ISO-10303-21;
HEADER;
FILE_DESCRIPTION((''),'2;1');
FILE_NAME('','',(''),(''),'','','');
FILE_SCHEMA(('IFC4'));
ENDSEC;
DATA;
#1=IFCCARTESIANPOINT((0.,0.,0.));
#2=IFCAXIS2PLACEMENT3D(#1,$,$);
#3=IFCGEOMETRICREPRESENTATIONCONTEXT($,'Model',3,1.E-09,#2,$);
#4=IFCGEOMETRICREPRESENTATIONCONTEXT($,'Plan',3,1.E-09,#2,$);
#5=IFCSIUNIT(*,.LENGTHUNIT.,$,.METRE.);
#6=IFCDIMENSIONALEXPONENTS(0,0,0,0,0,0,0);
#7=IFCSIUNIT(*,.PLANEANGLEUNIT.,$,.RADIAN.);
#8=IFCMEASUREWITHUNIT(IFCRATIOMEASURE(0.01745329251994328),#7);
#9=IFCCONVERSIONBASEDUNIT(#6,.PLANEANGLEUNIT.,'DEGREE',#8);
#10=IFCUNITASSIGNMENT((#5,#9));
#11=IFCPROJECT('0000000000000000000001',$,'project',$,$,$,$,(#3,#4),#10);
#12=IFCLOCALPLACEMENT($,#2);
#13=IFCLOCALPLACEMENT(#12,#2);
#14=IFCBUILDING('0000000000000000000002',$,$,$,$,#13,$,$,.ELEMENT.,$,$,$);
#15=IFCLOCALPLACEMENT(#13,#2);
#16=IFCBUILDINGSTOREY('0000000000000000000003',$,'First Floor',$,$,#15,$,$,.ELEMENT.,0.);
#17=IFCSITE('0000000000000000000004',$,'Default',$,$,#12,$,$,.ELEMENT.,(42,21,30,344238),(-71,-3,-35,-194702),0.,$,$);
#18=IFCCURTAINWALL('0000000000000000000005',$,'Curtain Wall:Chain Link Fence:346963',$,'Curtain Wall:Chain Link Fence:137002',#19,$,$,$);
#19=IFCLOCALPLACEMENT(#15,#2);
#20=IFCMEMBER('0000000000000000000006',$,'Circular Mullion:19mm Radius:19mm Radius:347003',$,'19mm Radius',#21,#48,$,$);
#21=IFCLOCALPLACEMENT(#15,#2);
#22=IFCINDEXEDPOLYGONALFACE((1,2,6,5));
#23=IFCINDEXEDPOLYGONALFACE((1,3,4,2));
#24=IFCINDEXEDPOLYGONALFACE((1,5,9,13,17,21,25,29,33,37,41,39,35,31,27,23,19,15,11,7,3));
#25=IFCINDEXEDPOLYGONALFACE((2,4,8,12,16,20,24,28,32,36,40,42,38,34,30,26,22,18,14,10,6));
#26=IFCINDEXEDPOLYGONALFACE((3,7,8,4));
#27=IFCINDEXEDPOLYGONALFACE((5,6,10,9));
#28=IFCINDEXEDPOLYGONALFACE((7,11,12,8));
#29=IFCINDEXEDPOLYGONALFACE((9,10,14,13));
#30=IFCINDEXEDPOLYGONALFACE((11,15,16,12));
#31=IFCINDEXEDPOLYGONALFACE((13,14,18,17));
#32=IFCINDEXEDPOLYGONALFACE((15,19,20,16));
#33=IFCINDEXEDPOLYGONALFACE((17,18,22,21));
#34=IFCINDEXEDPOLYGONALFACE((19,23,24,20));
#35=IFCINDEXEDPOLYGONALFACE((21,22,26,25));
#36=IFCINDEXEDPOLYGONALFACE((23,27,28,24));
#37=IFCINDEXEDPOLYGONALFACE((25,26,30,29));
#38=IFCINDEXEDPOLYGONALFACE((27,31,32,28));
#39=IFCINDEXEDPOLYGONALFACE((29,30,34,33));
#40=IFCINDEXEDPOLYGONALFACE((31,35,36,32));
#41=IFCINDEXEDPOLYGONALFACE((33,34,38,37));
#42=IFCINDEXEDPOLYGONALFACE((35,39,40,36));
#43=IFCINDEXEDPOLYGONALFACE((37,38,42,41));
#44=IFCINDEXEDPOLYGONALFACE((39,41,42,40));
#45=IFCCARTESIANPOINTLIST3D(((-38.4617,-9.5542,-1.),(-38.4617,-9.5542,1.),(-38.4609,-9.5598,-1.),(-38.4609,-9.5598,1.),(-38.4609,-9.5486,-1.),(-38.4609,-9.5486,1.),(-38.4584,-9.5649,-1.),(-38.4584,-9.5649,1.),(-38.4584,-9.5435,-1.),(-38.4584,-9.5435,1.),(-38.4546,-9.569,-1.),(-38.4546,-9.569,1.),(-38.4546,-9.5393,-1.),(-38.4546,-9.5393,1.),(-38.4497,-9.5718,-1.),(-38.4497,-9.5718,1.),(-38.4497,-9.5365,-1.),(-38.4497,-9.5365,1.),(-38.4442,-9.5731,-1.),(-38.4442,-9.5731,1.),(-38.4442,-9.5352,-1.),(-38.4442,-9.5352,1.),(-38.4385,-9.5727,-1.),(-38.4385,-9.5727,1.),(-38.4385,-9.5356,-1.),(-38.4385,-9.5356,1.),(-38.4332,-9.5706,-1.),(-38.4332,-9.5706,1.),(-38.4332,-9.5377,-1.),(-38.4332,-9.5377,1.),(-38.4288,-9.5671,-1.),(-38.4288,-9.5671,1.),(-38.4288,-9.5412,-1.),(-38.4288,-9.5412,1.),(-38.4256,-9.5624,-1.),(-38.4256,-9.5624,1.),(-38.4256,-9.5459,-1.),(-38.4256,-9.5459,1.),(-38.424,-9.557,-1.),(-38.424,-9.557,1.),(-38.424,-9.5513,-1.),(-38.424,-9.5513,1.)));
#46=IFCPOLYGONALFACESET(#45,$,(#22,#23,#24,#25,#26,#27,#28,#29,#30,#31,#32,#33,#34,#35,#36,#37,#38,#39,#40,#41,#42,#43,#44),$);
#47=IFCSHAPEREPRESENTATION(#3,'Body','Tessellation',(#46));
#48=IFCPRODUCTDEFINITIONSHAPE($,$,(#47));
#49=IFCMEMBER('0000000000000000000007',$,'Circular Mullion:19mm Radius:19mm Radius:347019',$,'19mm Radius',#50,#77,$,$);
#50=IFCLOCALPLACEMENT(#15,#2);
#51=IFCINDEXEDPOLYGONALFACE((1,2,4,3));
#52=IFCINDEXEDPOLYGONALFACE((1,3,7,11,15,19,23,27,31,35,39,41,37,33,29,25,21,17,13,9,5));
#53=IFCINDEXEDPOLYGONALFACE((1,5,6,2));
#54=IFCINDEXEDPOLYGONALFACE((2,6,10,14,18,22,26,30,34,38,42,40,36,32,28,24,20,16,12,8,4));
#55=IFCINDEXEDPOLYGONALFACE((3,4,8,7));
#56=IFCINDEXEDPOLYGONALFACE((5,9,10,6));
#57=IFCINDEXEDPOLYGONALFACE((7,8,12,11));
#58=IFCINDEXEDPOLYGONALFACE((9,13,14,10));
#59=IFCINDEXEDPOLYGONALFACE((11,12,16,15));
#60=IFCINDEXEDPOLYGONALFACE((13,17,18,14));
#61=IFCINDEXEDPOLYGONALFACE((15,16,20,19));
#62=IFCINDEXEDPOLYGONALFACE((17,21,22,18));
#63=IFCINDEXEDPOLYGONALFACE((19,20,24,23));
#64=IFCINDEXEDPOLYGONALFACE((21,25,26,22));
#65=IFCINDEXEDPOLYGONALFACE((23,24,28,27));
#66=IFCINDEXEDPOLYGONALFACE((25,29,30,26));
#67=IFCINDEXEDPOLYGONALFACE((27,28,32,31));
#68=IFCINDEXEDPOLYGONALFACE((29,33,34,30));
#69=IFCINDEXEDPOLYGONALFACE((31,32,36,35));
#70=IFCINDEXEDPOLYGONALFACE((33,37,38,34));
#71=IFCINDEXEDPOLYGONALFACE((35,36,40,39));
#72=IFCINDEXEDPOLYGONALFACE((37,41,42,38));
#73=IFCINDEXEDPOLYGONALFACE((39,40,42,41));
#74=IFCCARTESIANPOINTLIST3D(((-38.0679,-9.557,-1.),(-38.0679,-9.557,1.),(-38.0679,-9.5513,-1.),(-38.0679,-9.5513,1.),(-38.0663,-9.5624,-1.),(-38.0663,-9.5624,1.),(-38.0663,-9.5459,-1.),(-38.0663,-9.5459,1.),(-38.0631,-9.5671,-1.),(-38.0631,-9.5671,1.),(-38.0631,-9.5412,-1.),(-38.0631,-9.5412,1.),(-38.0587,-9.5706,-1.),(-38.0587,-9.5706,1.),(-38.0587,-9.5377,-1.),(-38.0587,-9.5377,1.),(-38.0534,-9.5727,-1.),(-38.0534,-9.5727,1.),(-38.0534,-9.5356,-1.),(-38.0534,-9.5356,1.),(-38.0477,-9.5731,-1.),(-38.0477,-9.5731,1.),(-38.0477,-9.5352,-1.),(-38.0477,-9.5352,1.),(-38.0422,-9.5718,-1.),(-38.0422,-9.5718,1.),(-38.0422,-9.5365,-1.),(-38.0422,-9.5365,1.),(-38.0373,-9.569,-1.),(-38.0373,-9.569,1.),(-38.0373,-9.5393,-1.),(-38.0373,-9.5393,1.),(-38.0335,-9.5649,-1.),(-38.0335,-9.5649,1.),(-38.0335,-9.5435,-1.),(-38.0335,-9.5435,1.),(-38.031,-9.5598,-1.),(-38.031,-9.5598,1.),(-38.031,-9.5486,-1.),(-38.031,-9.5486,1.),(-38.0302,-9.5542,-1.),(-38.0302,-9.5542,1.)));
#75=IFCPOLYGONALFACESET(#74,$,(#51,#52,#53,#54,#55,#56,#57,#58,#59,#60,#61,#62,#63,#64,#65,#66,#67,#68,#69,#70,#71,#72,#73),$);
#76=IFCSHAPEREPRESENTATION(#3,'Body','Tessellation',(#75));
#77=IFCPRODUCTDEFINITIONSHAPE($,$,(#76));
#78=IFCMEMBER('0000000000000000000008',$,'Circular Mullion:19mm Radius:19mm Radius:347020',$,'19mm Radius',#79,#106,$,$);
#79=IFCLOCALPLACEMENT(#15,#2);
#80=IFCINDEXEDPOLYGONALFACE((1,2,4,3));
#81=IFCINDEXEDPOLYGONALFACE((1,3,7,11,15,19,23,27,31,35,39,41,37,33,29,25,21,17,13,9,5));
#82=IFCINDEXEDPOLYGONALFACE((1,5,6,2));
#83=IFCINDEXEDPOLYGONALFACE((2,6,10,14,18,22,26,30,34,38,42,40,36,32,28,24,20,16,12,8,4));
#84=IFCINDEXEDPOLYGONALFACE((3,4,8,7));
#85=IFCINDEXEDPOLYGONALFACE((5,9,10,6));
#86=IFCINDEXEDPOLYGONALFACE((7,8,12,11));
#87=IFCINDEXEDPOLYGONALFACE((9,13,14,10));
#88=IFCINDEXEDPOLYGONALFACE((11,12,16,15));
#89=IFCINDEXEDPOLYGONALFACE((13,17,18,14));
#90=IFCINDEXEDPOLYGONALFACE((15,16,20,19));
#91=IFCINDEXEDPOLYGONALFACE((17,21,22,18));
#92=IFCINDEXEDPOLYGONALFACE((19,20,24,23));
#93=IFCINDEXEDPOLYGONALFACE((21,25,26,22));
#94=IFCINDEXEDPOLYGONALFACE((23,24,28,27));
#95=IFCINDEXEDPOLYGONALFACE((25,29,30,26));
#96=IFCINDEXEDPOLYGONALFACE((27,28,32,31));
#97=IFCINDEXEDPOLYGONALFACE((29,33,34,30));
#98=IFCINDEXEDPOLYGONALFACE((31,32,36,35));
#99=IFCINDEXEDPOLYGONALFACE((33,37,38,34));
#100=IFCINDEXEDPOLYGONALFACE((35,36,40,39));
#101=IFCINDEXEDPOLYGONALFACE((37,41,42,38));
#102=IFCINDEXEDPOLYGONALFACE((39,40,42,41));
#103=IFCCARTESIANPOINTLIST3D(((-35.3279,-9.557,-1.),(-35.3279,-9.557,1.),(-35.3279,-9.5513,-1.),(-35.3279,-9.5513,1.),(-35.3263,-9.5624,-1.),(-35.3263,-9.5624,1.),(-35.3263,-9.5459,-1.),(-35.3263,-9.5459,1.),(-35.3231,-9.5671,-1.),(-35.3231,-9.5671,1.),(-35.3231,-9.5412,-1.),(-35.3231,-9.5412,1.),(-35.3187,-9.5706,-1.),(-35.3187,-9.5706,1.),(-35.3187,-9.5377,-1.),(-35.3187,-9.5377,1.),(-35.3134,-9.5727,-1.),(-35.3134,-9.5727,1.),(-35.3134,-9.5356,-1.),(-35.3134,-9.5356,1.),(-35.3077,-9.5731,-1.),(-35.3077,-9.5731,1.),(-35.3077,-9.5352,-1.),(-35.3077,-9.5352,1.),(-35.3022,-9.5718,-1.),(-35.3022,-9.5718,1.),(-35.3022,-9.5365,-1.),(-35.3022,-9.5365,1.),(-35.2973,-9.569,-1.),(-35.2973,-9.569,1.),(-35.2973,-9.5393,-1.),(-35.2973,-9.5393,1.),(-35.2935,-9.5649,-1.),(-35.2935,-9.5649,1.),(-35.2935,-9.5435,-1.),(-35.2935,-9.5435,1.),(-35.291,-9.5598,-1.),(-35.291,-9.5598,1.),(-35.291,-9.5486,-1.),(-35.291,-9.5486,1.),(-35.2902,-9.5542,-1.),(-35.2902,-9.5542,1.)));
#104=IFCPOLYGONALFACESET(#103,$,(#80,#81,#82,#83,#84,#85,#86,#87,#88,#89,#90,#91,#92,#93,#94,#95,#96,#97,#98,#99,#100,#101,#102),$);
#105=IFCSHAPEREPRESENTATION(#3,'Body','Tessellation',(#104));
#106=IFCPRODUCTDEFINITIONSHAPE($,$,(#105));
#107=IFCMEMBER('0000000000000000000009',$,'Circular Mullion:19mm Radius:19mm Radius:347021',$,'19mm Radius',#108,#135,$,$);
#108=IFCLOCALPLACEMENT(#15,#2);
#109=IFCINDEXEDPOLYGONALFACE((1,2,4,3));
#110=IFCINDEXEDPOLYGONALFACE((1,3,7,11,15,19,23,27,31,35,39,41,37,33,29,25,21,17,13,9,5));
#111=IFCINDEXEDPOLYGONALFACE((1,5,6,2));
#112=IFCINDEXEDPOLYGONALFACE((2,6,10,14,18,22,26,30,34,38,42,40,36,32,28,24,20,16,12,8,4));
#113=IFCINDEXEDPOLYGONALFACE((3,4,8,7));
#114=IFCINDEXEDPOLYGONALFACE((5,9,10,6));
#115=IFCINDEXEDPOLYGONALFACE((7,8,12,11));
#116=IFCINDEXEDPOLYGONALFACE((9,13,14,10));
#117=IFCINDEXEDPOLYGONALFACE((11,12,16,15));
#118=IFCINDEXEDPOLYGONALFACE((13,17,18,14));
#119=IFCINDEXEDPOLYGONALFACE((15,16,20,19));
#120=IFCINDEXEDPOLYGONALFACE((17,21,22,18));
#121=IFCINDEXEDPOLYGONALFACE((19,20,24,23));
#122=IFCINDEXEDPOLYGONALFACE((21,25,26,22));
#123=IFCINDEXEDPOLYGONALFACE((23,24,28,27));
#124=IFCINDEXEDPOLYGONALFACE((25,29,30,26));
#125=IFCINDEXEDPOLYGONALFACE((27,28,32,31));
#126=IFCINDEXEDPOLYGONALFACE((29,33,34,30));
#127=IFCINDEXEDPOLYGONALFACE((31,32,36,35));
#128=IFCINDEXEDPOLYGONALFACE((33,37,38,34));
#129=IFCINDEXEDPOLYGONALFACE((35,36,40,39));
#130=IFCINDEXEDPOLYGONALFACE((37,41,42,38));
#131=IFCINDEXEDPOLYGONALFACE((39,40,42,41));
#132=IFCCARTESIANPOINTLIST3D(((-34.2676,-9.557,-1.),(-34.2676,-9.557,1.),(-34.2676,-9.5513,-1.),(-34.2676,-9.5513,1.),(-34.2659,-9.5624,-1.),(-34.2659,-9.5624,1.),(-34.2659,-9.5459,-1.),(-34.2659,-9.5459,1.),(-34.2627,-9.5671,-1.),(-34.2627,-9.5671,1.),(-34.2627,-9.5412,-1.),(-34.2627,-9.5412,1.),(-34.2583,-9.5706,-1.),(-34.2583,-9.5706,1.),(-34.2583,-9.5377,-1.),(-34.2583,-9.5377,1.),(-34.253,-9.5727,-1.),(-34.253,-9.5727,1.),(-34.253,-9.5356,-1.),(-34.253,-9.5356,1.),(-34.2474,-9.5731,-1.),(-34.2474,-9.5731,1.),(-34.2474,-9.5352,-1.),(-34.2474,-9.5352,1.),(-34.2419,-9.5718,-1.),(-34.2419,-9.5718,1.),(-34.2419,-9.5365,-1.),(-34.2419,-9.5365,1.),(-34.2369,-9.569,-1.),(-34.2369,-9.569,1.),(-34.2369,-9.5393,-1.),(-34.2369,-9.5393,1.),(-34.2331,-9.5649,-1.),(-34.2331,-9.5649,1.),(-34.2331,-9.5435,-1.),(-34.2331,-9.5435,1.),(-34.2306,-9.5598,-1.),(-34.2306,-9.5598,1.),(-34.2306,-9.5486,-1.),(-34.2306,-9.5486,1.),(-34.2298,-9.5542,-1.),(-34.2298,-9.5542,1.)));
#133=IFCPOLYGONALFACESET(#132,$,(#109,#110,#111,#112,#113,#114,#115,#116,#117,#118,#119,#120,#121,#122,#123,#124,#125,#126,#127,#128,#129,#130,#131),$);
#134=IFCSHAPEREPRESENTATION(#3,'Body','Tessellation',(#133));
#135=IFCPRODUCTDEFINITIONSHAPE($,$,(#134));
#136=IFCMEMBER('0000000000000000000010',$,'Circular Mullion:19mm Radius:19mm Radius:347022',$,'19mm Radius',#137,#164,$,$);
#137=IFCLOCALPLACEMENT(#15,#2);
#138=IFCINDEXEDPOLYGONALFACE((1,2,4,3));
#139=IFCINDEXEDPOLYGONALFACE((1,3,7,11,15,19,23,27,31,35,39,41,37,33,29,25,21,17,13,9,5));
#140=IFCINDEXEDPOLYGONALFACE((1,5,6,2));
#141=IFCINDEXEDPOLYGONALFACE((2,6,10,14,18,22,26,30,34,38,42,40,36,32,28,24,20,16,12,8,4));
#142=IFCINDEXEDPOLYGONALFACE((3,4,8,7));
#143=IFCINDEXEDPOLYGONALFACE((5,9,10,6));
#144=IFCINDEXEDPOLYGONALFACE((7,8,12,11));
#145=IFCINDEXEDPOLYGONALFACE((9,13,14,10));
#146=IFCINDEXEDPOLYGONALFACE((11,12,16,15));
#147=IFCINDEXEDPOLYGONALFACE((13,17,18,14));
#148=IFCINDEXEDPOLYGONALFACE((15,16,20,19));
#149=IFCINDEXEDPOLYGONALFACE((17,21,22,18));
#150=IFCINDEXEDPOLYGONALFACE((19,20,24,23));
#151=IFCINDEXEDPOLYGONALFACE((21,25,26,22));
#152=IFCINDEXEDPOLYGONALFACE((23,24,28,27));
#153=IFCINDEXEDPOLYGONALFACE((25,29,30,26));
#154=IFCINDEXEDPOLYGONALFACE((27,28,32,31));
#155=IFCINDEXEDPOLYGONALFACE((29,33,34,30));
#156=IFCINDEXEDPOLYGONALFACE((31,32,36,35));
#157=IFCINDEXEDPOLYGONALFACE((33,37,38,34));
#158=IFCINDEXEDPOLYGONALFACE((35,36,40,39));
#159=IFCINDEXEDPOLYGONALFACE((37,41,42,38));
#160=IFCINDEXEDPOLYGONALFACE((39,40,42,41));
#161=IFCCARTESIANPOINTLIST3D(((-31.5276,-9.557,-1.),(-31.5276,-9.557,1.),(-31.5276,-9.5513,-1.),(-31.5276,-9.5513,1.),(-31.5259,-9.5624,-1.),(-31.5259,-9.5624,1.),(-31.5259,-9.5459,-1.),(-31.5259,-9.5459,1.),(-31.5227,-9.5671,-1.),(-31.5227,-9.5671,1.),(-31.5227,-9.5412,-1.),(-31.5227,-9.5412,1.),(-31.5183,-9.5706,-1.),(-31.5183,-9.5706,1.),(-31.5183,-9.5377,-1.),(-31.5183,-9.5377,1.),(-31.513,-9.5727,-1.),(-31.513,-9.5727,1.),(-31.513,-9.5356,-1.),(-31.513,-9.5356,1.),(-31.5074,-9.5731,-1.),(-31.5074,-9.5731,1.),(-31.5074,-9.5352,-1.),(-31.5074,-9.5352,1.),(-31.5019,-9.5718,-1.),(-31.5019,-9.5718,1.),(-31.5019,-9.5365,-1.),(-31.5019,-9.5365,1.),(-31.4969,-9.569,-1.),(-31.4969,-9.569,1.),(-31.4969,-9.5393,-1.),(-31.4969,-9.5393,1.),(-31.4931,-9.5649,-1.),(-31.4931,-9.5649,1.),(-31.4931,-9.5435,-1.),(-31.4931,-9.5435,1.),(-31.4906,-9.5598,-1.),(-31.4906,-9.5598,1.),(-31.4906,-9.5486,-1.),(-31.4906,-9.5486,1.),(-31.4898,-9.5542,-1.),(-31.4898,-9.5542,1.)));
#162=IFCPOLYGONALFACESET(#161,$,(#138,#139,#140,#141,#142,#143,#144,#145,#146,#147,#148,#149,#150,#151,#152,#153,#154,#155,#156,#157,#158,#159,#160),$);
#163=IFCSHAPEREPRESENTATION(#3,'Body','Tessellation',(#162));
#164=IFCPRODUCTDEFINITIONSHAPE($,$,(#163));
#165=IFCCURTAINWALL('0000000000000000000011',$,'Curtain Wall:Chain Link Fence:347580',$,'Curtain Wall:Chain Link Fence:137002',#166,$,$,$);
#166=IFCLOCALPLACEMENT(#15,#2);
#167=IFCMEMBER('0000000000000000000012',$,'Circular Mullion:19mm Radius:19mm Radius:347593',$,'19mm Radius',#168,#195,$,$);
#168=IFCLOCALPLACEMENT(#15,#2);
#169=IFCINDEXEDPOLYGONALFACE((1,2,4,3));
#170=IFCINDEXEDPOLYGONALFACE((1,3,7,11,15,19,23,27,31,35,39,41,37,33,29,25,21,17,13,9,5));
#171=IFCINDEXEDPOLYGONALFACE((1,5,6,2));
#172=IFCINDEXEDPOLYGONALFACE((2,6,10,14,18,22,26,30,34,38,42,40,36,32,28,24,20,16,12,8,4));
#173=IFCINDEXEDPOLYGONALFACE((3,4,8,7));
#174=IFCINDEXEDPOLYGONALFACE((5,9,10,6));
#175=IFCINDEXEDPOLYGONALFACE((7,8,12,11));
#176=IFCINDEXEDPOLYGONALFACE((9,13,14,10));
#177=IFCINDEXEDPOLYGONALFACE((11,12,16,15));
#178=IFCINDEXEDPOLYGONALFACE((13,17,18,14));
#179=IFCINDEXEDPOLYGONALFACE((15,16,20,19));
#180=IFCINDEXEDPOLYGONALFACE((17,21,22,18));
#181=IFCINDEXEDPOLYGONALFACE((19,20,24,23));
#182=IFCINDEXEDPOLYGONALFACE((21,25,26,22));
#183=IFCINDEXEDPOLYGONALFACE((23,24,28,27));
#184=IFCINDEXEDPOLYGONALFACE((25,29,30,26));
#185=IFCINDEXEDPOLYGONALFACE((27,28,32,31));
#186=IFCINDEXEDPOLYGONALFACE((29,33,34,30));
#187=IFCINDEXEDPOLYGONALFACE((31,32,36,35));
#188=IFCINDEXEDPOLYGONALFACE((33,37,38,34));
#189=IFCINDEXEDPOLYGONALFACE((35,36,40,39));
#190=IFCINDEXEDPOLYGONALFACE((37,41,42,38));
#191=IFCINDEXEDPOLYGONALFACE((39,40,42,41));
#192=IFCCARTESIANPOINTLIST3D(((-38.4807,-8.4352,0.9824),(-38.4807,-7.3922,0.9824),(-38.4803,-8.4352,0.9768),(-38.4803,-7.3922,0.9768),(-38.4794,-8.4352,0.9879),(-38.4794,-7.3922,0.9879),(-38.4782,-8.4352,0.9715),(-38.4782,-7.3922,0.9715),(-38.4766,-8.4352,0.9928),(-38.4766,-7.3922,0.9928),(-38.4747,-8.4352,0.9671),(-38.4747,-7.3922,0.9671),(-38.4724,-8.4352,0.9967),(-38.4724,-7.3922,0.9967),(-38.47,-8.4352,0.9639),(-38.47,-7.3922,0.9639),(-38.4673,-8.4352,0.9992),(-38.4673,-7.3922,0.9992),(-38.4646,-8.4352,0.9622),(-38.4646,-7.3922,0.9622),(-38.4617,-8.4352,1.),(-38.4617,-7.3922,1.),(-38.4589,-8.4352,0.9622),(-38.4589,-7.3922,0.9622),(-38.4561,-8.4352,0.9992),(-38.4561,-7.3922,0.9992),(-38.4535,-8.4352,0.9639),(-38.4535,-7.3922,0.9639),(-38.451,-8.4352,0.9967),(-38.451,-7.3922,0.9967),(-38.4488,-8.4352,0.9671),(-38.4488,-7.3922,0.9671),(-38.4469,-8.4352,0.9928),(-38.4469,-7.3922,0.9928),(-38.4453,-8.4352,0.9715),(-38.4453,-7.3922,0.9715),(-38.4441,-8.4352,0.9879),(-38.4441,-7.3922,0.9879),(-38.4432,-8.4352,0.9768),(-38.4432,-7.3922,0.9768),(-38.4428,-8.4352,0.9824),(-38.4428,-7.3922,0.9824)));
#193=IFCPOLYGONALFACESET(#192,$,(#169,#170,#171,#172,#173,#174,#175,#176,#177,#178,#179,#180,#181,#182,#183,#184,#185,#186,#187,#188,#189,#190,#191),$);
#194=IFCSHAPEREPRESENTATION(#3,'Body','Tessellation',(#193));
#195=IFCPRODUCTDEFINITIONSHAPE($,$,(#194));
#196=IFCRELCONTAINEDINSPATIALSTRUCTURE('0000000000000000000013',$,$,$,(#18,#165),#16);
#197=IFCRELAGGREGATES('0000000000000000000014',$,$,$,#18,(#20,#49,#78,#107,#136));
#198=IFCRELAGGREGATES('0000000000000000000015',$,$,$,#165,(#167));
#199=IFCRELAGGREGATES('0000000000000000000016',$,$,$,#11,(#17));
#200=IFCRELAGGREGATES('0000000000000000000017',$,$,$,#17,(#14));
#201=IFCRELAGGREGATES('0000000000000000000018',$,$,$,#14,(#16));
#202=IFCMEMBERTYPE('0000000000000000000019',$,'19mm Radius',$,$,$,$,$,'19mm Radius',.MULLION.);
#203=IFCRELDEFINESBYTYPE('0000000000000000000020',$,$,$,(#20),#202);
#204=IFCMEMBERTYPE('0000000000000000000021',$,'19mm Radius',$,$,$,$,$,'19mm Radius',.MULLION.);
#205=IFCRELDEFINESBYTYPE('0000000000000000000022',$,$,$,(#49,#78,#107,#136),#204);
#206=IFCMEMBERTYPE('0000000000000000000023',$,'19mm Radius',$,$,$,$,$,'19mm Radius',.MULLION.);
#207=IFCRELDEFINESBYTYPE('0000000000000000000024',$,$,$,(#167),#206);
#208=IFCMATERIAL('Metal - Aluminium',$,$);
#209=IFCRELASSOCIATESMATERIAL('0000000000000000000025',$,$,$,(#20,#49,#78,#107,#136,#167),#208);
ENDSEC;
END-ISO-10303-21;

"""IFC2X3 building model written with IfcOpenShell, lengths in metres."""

from ifc_helpers import new_model, entity, si_unit, converted_unit, frame, origin, origin_2d_with_axis, place, context, project, spatial, circle, extrude, source, transform, mapped, material, type_object, type_shapes, element, aggregate, save


model = new_model("IFC2X3")

# Units and contexts
model_context = context("Model", 3, precision=1e-09, world=origin())
plan_context = context("Plan", 3, precision=1e-09, world=origin())
ifc_project = project(units=[si_unit("LENGTHUNIT", "METRE"), converted_unit("PLANEANGLEUNIT", "DEGREE", entity("IfcRatioMeasure", 0.01745329251994328), si_unit("PLANEANGLEUNIT", "RADIAN"), dimensions=[0, 0, 0, 0, 0, 0, 0])], contexts=[model_context, plan_context])

# Site, building, storey
site_placement = place(None, origin())
site = spatial("IfcSite", under=ifc_project, at=site_placement, Name="Default", CompositionType="ELEMENT", RefLatitude=(42, 21, 30, 344238), RefLongitude=(-71, -3, -35, -194702), RefElevation=0.0)
building_placement = place(site_placement, origin())
building = spatial("IfcBuilding", under=site, at=building_placement, CompositionType="ELEMENT")
storey_placement = place(building_placement, origin())
storey = spatial("IfcBuildingStorey", under=building, at=storey_placement, Name="First Floor", CompositionType="ELEMENT", Elevation=0.0)

# Curtain walls, members
curtain_wall_1_placement = place(storey_placement, origin())
curtain_wall_1 = element("IfcCurtainWall", 1, at=curtain_wall_1_placement, inside=storey, Name="Curtain Wall:Chain Link Fence:346963", ObjectType="Curtain Wall:Chain Link Fence:137002")
ifc_material_1 = material(Name="Metal - Aluminium")
placement = place(building_placement, frame((0.0, 0.0, -1.0)))
member_type_1 = type_object("IfcMemberType", Name="19mm Radius", ElementType="19mm Radius", PredefinedType="MULLION")
shared_shape_1 = source(origin(), model_context, "Body", "SweptSolid", [
    extrude(circle(Radius=0.019, at=origin_2d_with_axis()), frame((-0.019, 0.0, -2.0)), (0.0, 0.0, 1.0), 2.0),
])
type_shapes(member_type_1, [shared_shape_1])
member_1_placement = place(placement, frame((-38.4617, -9.5542, 2.0), z_axis=(0.0, 0.0, 1.0), x_axis=(-1.0, 0.0, 0.0)))
member_1 = element("IfcMember", 2, at=member_1_placement, type_object=member_type_1, material=ifc_material_1, Name="Circular Mullion:19mm Radius:19mm Radius:347003", ObjectType="19mm Radius", context=model_context, shape_type="MappedRepresentation", body=[
    mapped(shared_shape_1, transform((0.0, 0.0, 0.0), scale=1.0)),
])
member_type_2 = type_object("IfcMemberType", Name="19mm Radius", ElementType="19mm Radius", PredefinedType="MULLION")
shared_shape_2 = source(origin(), model_context, "Body", "SweptSolid", [
    extrude(circle(Radius=0.019, at=origin_2d_with_axis()), frame((0.0, 0.0, -2.0)), (0.0, 0.0, 1.0), 2.0),
])
type_shapes(member_type_2, [shared_shape_2])
member_2_placement = place(placement, frame((-38.0492, -9.5542, 0.0), z_axis=(0.0, 0.0, -1.0), x_axis=(1.0, 0.0, 0.0)))
member_2 = element("IfcMember", 3, at=member_2_placement, type_object=member_type_2, material=ifc_material_1, Name="Circular Mullion:19mm Radius:19mm Radius:347019", ObjectType="19mm Radius", context=model_context, shape_type="MappedRepresentation", body=[
    mapped(shared_shape_2, transform((0.0, 0.0, 0.0), scale=1.0)),
])
member_3_placement = place(placement, frame((-35.3092, -9.5542, 0.0), z_axis=(0.0, 0.0, -1.0), x_axis=(1.0, 0.0, 0.0)))
member_3 = element("IfcMember", 4, at=member_3_placement, type_object=member_type_2, material=ifc_material_1, Name="Circular Mullion:19mm Radius:19mm Radius:347020", ObjectType="19mm Radius", context=model_context, shape_type="MappedRepresentation", body=[
    mapped(shared_shape_2, transform((0.0, 0.0, 0.0), scale=1.0)),
])
member_4_placement = place(placement, frame((-34.2488, -9.5542, 0.0), z_axis=(0.0, 0.0, -1.0), x_axis=(1.0, 0.0, 0.0)))
member_4 = element("IfcMember", 5, at=member_4_placement, type_object=member_type_2, material=ifc_material_1, Name="Circular Mullion:19mm Radius:19mm Radius:347021", ObjectType="19mm Radius", context=model_context, shape_type="MappedRepresentation", body=[
    mapped(shared_shape_2, transform((0.0, 0.0, 0.0), scale=1.0)),
])
member_5_placement = place(placement, frame((-31.5088, -9.5542, 0.0), z_axis=(0.0, 0.0, -1.0), x_axis=(1.0, 0.0, 0.0)))
member_5 = element("IfcMember", 6, at=member_5_placement, type_object=member_type_2, material=ifc_material_1, Name="Circular Mullion:19mm Radius:19mm Radius:347022", ObjectType="19mm Radius", context=model_context, shape_type="MappedRepresentation", body=[
    mapped(shared_shape_2, transform((0.0, 0.0, 0.0), scale=1.0)),
])
curtain_wall_2_placement = place(storey_placement, origin())
curtain_wall_2 = element("IfcCurtainWall", 7, at=curtain_wall_2_placement, inside=storey, Name="Curtain Wall:Chain Link Fence:347580", ObjectType="Curtain Wall:Chain Link Fence:137002")
member_type_3 = type_object("IfcMemberType", Name="19mm Radius", ElementType="19mm Radius", PredefinedType="MULLION")
shared_shape_3 = source(origin(), model_context, "Body", "SweptSolid", [
    extrude(circle(Radius=0.019, at=origin_2d_with_axis()), frame((-0.019, 0.0, -1.043)), (0.0, 0.0, 1.0), 1.043),
])
type_shapes(member_type_3, [shared_shape_3])
member_6_placement = place(storey_placement, frame((-38.4617, -7.3922, 1.0), z_axis=(0.0, 1.0, 0.0), x_axis=(0.0, 0.0, 1.0)))
member_6 = element("IfcMember", 8, at=member_6_placement, type_object=member_type_3, material=ifc_material_1, Name="Circular Mullion:19mm Radius:19mm Radius:347593", ObjectType="19mm Radius", context=model_context, shape_type="MappedRepresentation", body=[
    mapped(shared_shape_3, transform((0.0, 0.0, 0.0), scale=1.0)),
])

aggregate(curtain_wall_1, [member_1, member_2, member_3, member_4, member_5])
aggregate(curtain_wall_2, [member_6])

save(model, "model.ifc")
